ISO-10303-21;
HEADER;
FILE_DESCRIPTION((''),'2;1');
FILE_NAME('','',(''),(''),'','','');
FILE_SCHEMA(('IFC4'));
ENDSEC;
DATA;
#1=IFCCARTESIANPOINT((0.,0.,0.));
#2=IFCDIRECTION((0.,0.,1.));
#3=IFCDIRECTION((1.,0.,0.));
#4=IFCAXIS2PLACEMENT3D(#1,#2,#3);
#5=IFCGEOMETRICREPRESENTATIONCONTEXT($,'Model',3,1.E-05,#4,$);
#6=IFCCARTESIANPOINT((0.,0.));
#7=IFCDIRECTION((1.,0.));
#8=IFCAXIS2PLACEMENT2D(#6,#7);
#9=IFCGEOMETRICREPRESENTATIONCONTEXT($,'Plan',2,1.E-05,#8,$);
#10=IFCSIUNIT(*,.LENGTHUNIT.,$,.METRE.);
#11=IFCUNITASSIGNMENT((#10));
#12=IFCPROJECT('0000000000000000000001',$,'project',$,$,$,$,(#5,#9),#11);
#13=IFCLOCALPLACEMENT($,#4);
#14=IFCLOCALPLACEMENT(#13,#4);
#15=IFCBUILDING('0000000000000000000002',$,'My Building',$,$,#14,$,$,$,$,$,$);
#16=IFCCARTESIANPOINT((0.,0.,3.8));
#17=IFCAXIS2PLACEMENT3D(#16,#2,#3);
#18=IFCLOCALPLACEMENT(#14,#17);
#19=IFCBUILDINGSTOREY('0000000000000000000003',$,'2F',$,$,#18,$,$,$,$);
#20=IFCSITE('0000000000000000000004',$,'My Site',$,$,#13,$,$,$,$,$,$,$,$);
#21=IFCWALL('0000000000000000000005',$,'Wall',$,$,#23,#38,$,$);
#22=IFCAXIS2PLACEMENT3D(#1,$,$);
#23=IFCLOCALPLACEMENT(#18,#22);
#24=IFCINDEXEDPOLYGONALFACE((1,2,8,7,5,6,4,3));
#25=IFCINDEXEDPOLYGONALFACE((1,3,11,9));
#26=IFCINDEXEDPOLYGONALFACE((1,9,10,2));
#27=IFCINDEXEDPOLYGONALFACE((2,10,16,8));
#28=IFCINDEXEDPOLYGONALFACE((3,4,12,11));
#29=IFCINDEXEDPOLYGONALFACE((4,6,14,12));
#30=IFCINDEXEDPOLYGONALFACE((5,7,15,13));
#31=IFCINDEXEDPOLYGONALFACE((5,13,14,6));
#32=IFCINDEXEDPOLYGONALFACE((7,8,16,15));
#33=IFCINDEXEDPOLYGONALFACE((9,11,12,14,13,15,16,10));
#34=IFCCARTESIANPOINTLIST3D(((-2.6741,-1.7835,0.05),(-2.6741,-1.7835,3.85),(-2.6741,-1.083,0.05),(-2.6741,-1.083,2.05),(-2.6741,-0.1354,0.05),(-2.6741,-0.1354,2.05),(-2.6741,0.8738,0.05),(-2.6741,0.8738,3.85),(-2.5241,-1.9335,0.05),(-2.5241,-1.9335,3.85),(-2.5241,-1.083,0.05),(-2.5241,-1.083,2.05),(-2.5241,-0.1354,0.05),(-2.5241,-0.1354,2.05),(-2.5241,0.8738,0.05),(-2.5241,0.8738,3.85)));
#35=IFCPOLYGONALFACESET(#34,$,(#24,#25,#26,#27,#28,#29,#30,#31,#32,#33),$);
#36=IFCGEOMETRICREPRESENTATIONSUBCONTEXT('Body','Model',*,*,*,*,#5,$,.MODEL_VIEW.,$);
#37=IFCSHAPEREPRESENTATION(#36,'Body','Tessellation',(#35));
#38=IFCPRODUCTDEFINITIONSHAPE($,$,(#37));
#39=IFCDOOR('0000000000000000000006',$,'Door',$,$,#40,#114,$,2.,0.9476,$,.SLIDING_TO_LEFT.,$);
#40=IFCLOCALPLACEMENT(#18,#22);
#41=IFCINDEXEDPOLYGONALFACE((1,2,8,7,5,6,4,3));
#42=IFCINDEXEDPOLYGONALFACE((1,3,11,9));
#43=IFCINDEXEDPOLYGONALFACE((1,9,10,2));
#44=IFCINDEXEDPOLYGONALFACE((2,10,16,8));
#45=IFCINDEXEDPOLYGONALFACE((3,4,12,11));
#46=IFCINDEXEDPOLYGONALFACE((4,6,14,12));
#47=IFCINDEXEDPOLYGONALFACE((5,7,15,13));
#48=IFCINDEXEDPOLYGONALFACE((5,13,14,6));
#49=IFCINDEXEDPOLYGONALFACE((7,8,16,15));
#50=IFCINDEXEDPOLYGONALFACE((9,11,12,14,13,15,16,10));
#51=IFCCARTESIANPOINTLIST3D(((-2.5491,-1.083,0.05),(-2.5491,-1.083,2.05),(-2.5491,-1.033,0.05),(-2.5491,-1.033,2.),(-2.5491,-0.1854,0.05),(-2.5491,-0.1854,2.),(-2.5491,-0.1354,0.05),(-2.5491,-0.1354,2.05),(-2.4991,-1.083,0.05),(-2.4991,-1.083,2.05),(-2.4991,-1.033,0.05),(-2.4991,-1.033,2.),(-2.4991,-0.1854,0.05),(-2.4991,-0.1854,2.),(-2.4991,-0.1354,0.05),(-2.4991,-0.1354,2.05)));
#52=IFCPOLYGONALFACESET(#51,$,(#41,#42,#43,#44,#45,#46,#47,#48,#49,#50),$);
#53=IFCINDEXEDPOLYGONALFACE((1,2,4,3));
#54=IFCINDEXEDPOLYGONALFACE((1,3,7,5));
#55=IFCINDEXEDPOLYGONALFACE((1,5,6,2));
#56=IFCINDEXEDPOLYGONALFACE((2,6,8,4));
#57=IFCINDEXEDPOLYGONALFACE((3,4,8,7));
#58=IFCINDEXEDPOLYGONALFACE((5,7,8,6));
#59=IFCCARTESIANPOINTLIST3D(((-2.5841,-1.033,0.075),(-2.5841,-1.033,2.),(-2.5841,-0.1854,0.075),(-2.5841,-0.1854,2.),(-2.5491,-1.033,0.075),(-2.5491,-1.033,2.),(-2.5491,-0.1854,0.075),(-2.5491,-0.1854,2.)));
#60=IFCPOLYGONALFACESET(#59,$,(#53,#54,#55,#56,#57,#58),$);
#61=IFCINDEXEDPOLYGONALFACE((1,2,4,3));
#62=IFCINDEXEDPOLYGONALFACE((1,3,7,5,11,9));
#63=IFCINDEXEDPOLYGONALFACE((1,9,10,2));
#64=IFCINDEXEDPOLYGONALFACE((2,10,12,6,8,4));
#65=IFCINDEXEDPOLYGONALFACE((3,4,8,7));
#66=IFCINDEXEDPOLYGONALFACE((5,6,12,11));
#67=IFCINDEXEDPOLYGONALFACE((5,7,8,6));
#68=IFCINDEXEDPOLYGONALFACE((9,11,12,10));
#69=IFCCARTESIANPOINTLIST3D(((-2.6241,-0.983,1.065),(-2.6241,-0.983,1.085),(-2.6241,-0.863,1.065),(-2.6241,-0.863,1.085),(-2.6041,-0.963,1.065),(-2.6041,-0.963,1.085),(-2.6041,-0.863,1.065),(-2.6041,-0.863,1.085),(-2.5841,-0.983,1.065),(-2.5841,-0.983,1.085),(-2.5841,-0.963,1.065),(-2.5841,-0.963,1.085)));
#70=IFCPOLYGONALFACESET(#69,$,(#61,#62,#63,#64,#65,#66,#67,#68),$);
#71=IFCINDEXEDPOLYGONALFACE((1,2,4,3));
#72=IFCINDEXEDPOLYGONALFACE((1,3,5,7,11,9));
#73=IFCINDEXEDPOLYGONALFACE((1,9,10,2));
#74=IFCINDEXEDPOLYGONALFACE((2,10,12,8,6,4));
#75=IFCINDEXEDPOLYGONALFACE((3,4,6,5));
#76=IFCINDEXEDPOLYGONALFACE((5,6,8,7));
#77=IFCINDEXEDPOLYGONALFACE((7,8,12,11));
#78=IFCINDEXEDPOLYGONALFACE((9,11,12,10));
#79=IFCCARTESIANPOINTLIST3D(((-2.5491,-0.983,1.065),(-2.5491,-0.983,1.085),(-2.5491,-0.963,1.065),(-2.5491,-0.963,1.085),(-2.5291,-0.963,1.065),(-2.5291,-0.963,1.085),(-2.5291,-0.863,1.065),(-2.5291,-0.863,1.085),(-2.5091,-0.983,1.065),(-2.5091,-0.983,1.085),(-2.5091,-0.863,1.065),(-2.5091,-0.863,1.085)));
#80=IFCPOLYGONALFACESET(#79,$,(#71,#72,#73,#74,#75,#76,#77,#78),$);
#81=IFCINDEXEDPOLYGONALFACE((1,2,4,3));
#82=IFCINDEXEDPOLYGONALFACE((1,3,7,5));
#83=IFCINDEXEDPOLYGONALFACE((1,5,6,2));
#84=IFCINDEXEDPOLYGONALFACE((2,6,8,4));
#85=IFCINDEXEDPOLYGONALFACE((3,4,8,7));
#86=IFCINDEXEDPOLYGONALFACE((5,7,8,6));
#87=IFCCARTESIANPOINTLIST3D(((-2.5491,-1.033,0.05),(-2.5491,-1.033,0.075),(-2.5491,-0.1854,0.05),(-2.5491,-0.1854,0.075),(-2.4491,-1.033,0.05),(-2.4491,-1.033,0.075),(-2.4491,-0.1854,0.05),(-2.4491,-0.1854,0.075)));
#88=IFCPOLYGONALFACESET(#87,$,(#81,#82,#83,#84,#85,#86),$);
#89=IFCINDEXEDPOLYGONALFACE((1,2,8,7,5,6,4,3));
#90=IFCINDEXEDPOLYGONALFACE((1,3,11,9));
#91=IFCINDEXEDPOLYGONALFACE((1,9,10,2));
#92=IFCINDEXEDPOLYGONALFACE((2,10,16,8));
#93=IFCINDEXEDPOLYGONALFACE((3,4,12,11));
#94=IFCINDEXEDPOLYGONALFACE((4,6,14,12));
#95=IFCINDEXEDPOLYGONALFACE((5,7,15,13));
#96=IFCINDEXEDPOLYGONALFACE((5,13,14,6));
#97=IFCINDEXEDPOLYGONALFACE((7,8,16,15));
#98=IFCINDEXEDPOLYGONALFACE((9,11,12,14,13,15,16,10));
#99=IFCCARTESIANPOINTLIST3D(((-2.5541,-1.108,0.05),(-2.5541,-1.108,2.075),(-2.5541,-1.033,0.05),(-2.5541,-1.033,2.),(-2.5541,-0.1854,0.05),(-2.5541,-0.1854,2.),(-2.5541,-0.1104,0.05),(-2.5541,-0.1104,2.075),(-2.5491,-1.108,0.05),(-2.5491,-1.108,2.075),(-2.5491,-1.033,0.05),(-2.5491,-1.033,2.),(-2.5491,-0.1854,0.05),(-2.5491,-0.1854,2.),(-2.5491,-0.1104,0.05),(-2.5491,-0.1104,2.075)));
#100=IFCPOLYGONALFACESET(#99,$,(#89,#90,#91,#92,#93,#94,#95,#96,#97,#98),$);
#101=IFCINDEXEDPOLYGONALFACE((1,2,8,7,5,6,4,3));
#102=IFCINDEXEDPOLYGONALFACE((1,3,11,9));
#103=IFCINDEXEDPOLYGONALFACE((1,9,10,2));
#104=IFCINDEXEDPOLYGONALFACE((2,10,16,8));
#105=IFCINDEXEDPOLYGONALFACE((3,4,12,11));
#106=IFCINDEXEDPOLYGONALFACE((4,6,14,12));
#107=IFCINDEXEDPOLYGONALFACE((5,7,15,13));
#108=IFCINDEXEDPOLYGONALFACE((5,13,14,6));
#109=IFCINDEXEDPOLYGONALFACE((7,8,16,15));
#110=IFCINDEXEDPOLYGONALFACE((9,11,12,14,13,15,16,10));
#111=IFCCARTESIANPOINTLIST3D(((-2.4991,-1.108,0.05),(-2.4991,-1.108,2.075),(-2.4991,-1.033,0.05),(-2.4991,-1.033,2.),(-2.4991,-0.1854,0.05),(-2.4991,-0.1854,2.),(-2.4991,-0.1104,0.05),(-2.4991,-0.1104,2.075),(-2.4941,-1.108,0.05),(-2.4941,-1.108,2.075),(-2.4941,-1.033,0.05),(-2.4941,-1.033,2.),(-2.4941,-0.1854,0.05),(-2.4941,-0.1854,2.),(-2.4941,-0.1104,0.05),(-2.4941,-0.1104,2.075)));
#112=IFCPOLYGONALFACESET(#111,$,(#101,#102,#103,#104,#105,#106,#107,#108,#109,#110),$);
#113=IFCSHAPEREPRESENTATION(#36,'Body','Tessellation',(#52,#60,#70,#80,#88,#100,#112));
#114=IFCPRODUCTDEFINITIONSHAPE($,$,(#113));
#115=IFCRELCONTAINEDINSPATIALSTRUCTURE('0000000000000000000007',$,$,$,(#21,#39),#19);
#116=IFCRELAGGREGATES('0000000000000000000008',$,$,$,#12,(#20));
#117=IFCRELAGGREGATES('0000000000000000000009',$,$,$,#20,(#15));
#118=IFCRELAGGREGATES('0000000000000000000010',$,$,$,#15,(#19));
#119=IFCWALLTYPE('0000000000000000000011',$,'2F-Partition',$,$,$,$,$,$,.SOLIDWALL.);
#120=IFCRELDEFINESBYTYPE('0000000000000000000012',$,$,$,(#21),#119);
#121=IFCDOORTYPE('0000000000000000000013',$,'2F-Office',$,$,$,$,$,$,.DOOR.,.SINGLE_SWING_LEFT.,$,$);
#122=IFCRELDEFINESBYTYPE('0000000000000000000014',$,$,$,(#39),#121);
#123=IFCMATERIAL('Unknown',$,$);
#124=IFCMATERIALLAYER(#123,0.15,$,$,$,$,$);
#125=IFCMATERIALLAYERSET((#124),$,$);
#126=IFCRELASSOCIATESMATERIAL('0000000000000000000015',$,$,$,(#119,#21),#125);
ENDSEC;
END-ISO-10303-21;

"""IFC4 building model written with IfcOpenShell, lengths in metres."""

from ifc_helpers import new_model, entity, si_unit, frame, origin_with_axes, origin_2d_with_axis, place, context, subcontext, project, spatial, line, indexed_curve, outline, extrude, shape, source, transform, mapped, material, layer, layer_set, layer_usage, type_object, type_shapes, element, fill, save


model = new_model("IFC4")

# Units and contexts
model_context = context("Model", 3, precision=1e-05, world=origin_with_axes())
plan_context = context("Plan", 2, precision=1e-05, world=origin_2d_with_axis())
body_context_1 = subcontext(model_context, "Body", "Model", "MODEL_VIEW")
body_context_2 = subcontext(plan_context, "Body", "Plan", "PLAN_VIEW")
ifc_project = project(units=[si_unit("LENGTHUNIT", "METRE")], contexts=[model_context, plan_context])

# Site, building, storey
site_placement = place(None, origin_with_axes())
site = spatial("IfcSite", under=ifc_project, at=site_placement, Name="My Site")
building_placement = place(site_placement, origin_with_axes())
building = spatial("IfcBuilding", under=site, at=building_placement, Name="My Building")
storey_placement = place(building_placement, frame((0.0, 0.0, 3.8), z_axis=(0.0, 0.0, 1.0), x_axis=(1.0, 0.0, 0.0)))
storey = spatial("IfcBuildingStorey", under=building, at=storey_placement, Name="2F")

# Shared definitions
ifc_material = material(Name="Unknown")

# Wall, opening, door
ifc_layer_1 = layer(ifc_material, 0.15)
ifc_layer_set_1 = layer_set([ifc_layer_1])
ifc_layer_usage_1 = layer_usage(ifc_layer_set_1, "AXIS2", "POSITIVE", 0.0)
wall_type_1 = type_object("IfcWallType", Name="2F-Partition", PredefinedType="SOLIDWALL", material=ifc_layer_set_1)
wall_1_placement = place(storey_placement, frame((-2.6741, 1.0238, 0.05), z_axis=(0.0, 0.0, 1.0), x_axis=(0.0, -1.0, 0.0)))
wall_1 = element("IfcWall", 1, at=wall_1_placement, inside=storey, type_object=wall_type_1, material=ifc_layer_usage_1, Name="Wall", context=body_context_1, shape_type="SweptSolid", body=[
    extrude(outline(indexed_curve([(0.15, 0.0), (0.15, 0.15), (2.9573, 0.15), (2.8073, 0.0)], segments=[line(1, 2, 3, 4, 1)])), origin_with_axes(), (0.0, 0.0, 1.0), 3.8),
])
shared_shape_1 = source(origin_with_axes(), body_context_1, "Body", "SweptSolid", [
    extrude(outline(indexed_curve([(0.0, 0.0), (0.9476, 0.0), (0.9476, 2.0), (0.0, 2.0)], segments=[line(1, 2, 3, 4, 1)])), frame((0.0, -0.6, 0.0), z_axis=(0.0, -1.0, 0.0), x_axis=(1.0, 0.0, 0.0)), (0.0, 0.0, -1.0), 1.2),
])
opening_1_placement = place(wall_1_placement, frame((1.1592, 0.125, 0.0), z_axis=(0.0, 0.0, 1.0), x_axis=(1.0, 0.0, 0.0)))
opening_1 = element("IfcOpeningElement", 2, at=opening_1_placement, cuts=wall_1, PredefinedType="OPENING", context=body_context_1, shape_type="MappedRepresentation", body=[
    mapped(shared_shape_1, transform((0.0, 0.0, 0.0), x_axis=(1.0, 0.0, 0.0), y_axis=(0.0, 1.0, 0.0), z_axis=(0.0, 0.0, 1.0), scale=1.0)),
])
door_type = type_object("IfcDoorType", Name="2F-Office", OperationType="SINGLE_SWING_LEFT", PredefinedType="DOOR")
shared_shape_2 = source(origin_with_axes(), body_context_1, "Body", "SweptSolid", [
    extrude(outline(indexed_curve([(0.0, 0.0), (0.0, 2.0), (0.9476, 2.0), (0.9476, 0.0), (0.8976, 0.0), (0.8976, 1.95), (0.05, 1.95), (0.05, 0.0)], segments=[line(1, 2, 3, 4, 5, 6, 7, 8, 1)])), frame((0.0, 0.0, 0.0), z_axis=(0.0, -1.0, 0.0), x_axis=(1.0, 0.0, 0.0)), (0.0, 0.0, -1.0), 0.05),
    extrude(outline(indexed_curve([(0.0, 0.0), (0.8476, 0.0), (0.8476, 0.035), (0.0, 0.035)], segments=[line(1, 2, 3, 4, 1)])), frame((0.05, -0.035, 0.025), z_axis=(0.0, 0.0, 1.0), x_axis=(1.0, 0.0, 0.0)), (0.0, 0.0, 1.0), 1.925),
    extrude(outline(indexed_curve([(0.0, 0.0), (0.0, -0.04), (-0.12, -0.04), (-0.12, -0.02), (-0.02, -0.02), (-0.02, 0.0)], segments=[line(1, 2, 3, 4, 5, 6, 1)])), frame((0.8476, -0.035, 1.015), z_axis=(0.0, 0.0, 1.0), x_axis=(1.0, 0.0, 0.0)), (0.0, 0.0, 1.0), 0.02),
    extrude(outline(indexed_curve([(0.0, 0.0), (0.0, 0.04), (-0.12, 0.04), (-0.12, 0.02), (-0.02, 0.02), (-0.02, 0.0)], segments=[line(1, 2, 3, 4, 5, 6, 1)])), frame((0.8476, 0.0, 1.015), z_axis=(0.0, 0.0, 1.0), x_axis=(1.0, 0.0, 0.0)), (0.0, 0.0, 1.0), 0.02),
    extrude(outline(indexed_curve([(0.0, 0.0), (0.8476, 0.0), (0.8476, 0.1), (0.0, 0.1)], segments=[line(1, 2, 3, 4, 1)])), frame((0.05, 0.0, 0.0), z_axis=(0.0, 0.0, 1.0), x_axis=(1.0, 0.0, 0.0)), (0.0, 0.0, 1.0), 0.025),
    extrude(outline(indexed_curve([(0.0, 0.0), (0.0, 2.025), (0.9976, 2.025), (0.9976, 0.0), (0.9226, 0.0), (0.9226, 1.95), (0.075, 1.95), (0.075, 0.0)], segments=[line(1, 2, 3, 4, 5, 6, 7, 8, 1)])), frame((-0.025, -0.005, 0.0), z_axis=(0.0, -1.0, 0.0), x_axis=(1.0, 0.0, 0.0)), (0.0, 0.0, -1.0), 0.005),
    extrude(outline(indexed_curve([(0.0, 0.0), (0.0, 2.025), (0.9976, 2.025), (0.9976, 0.0), (0.9226, 0.0), (0.9226, 1.95), (0.075, 1.95), (0.075, 0.0)], segments=[line(1, 2, 3, 4, 5, 6, 7, 8, 1)])), frame((-0.025, 0.05, 0.0), z_axis=(0.0, -1.0, 0.0), x_axis=(1.0, 0.0, 0.0)), (0.0, 0.0, -1.0), 0.005),
])
shared_shape_3 = source(origin_with_axes(), body_context_2, "Body", "Curve2D", [
    entity("IfcIndexedPolyCurve", entity("IfcCartesianPointList2D", [[0.0, 0.0], [0.05, 0.0], [0.05, 0.05], [0.0, 0.05]]), [entity("IfcLineIndex", [1, 2, 3, 4, 1])]),
    entity("IfcIndexedPolyCurve", entity("IfcCartesianPointList2D", [[0.9476, 0.0], [0.8976, 0.0], [0.8976, 0.05], [0.9476, 0.05]]), [entity("IfcLineIndex", [1, 2, 3, 4, 1])]),
    entity("IfcIndexedPolyCurve", entity("IfcCartesianPointList2D", [[-0.3738, -0.035], [0.4738, -0.035], [0.4738, 0.0], [-0.3738, 0.0]]), [entity("IfcLineIndex", [1, 2, 3, 4, 1])]),
])
type_shapes(door_type, [shared_shape_2, shared_shape_3])
door_placement = place(opening_1_placement, frame((0.0, 0.0, 0.0), z_axis=(0.0, 0.0, 1.0), x_axis=(1.0, 0.0, 0.0)))
door = element("IfcDoor", 3, at=door_placement, inside=storey, type_object=door_type, Name="Door", OperationType="SLIDING_TO_LEFT", OverallHeight=2.0, OverallWidth=0.9476, shapes=[
    shape(body_context_1, "Body", "MappedRepresentation", [mapped(shared_shape_2, transform((0.0, 0.0, 0.0), x_axis=(1.0, 0.0, 0.0), y_axis=(0.0, 1.0, 0.0), z_axis=(0.0, 0.0, 1.0), scale=1.0))]),
    shape(body_context_2, "Body", "MappedRepresentation", [mapped(shared_shape_3, transform((0.0, 0.0, 0.0), x_axis=(1.0, 0.0, 0.0), y_axis=(0.0, 1.0, 0.0), z_axis=(0.0, 0.0, 1.0), scale=1.0))]),
])
fill(opening_1, door)

save(model, "model.ifc")
